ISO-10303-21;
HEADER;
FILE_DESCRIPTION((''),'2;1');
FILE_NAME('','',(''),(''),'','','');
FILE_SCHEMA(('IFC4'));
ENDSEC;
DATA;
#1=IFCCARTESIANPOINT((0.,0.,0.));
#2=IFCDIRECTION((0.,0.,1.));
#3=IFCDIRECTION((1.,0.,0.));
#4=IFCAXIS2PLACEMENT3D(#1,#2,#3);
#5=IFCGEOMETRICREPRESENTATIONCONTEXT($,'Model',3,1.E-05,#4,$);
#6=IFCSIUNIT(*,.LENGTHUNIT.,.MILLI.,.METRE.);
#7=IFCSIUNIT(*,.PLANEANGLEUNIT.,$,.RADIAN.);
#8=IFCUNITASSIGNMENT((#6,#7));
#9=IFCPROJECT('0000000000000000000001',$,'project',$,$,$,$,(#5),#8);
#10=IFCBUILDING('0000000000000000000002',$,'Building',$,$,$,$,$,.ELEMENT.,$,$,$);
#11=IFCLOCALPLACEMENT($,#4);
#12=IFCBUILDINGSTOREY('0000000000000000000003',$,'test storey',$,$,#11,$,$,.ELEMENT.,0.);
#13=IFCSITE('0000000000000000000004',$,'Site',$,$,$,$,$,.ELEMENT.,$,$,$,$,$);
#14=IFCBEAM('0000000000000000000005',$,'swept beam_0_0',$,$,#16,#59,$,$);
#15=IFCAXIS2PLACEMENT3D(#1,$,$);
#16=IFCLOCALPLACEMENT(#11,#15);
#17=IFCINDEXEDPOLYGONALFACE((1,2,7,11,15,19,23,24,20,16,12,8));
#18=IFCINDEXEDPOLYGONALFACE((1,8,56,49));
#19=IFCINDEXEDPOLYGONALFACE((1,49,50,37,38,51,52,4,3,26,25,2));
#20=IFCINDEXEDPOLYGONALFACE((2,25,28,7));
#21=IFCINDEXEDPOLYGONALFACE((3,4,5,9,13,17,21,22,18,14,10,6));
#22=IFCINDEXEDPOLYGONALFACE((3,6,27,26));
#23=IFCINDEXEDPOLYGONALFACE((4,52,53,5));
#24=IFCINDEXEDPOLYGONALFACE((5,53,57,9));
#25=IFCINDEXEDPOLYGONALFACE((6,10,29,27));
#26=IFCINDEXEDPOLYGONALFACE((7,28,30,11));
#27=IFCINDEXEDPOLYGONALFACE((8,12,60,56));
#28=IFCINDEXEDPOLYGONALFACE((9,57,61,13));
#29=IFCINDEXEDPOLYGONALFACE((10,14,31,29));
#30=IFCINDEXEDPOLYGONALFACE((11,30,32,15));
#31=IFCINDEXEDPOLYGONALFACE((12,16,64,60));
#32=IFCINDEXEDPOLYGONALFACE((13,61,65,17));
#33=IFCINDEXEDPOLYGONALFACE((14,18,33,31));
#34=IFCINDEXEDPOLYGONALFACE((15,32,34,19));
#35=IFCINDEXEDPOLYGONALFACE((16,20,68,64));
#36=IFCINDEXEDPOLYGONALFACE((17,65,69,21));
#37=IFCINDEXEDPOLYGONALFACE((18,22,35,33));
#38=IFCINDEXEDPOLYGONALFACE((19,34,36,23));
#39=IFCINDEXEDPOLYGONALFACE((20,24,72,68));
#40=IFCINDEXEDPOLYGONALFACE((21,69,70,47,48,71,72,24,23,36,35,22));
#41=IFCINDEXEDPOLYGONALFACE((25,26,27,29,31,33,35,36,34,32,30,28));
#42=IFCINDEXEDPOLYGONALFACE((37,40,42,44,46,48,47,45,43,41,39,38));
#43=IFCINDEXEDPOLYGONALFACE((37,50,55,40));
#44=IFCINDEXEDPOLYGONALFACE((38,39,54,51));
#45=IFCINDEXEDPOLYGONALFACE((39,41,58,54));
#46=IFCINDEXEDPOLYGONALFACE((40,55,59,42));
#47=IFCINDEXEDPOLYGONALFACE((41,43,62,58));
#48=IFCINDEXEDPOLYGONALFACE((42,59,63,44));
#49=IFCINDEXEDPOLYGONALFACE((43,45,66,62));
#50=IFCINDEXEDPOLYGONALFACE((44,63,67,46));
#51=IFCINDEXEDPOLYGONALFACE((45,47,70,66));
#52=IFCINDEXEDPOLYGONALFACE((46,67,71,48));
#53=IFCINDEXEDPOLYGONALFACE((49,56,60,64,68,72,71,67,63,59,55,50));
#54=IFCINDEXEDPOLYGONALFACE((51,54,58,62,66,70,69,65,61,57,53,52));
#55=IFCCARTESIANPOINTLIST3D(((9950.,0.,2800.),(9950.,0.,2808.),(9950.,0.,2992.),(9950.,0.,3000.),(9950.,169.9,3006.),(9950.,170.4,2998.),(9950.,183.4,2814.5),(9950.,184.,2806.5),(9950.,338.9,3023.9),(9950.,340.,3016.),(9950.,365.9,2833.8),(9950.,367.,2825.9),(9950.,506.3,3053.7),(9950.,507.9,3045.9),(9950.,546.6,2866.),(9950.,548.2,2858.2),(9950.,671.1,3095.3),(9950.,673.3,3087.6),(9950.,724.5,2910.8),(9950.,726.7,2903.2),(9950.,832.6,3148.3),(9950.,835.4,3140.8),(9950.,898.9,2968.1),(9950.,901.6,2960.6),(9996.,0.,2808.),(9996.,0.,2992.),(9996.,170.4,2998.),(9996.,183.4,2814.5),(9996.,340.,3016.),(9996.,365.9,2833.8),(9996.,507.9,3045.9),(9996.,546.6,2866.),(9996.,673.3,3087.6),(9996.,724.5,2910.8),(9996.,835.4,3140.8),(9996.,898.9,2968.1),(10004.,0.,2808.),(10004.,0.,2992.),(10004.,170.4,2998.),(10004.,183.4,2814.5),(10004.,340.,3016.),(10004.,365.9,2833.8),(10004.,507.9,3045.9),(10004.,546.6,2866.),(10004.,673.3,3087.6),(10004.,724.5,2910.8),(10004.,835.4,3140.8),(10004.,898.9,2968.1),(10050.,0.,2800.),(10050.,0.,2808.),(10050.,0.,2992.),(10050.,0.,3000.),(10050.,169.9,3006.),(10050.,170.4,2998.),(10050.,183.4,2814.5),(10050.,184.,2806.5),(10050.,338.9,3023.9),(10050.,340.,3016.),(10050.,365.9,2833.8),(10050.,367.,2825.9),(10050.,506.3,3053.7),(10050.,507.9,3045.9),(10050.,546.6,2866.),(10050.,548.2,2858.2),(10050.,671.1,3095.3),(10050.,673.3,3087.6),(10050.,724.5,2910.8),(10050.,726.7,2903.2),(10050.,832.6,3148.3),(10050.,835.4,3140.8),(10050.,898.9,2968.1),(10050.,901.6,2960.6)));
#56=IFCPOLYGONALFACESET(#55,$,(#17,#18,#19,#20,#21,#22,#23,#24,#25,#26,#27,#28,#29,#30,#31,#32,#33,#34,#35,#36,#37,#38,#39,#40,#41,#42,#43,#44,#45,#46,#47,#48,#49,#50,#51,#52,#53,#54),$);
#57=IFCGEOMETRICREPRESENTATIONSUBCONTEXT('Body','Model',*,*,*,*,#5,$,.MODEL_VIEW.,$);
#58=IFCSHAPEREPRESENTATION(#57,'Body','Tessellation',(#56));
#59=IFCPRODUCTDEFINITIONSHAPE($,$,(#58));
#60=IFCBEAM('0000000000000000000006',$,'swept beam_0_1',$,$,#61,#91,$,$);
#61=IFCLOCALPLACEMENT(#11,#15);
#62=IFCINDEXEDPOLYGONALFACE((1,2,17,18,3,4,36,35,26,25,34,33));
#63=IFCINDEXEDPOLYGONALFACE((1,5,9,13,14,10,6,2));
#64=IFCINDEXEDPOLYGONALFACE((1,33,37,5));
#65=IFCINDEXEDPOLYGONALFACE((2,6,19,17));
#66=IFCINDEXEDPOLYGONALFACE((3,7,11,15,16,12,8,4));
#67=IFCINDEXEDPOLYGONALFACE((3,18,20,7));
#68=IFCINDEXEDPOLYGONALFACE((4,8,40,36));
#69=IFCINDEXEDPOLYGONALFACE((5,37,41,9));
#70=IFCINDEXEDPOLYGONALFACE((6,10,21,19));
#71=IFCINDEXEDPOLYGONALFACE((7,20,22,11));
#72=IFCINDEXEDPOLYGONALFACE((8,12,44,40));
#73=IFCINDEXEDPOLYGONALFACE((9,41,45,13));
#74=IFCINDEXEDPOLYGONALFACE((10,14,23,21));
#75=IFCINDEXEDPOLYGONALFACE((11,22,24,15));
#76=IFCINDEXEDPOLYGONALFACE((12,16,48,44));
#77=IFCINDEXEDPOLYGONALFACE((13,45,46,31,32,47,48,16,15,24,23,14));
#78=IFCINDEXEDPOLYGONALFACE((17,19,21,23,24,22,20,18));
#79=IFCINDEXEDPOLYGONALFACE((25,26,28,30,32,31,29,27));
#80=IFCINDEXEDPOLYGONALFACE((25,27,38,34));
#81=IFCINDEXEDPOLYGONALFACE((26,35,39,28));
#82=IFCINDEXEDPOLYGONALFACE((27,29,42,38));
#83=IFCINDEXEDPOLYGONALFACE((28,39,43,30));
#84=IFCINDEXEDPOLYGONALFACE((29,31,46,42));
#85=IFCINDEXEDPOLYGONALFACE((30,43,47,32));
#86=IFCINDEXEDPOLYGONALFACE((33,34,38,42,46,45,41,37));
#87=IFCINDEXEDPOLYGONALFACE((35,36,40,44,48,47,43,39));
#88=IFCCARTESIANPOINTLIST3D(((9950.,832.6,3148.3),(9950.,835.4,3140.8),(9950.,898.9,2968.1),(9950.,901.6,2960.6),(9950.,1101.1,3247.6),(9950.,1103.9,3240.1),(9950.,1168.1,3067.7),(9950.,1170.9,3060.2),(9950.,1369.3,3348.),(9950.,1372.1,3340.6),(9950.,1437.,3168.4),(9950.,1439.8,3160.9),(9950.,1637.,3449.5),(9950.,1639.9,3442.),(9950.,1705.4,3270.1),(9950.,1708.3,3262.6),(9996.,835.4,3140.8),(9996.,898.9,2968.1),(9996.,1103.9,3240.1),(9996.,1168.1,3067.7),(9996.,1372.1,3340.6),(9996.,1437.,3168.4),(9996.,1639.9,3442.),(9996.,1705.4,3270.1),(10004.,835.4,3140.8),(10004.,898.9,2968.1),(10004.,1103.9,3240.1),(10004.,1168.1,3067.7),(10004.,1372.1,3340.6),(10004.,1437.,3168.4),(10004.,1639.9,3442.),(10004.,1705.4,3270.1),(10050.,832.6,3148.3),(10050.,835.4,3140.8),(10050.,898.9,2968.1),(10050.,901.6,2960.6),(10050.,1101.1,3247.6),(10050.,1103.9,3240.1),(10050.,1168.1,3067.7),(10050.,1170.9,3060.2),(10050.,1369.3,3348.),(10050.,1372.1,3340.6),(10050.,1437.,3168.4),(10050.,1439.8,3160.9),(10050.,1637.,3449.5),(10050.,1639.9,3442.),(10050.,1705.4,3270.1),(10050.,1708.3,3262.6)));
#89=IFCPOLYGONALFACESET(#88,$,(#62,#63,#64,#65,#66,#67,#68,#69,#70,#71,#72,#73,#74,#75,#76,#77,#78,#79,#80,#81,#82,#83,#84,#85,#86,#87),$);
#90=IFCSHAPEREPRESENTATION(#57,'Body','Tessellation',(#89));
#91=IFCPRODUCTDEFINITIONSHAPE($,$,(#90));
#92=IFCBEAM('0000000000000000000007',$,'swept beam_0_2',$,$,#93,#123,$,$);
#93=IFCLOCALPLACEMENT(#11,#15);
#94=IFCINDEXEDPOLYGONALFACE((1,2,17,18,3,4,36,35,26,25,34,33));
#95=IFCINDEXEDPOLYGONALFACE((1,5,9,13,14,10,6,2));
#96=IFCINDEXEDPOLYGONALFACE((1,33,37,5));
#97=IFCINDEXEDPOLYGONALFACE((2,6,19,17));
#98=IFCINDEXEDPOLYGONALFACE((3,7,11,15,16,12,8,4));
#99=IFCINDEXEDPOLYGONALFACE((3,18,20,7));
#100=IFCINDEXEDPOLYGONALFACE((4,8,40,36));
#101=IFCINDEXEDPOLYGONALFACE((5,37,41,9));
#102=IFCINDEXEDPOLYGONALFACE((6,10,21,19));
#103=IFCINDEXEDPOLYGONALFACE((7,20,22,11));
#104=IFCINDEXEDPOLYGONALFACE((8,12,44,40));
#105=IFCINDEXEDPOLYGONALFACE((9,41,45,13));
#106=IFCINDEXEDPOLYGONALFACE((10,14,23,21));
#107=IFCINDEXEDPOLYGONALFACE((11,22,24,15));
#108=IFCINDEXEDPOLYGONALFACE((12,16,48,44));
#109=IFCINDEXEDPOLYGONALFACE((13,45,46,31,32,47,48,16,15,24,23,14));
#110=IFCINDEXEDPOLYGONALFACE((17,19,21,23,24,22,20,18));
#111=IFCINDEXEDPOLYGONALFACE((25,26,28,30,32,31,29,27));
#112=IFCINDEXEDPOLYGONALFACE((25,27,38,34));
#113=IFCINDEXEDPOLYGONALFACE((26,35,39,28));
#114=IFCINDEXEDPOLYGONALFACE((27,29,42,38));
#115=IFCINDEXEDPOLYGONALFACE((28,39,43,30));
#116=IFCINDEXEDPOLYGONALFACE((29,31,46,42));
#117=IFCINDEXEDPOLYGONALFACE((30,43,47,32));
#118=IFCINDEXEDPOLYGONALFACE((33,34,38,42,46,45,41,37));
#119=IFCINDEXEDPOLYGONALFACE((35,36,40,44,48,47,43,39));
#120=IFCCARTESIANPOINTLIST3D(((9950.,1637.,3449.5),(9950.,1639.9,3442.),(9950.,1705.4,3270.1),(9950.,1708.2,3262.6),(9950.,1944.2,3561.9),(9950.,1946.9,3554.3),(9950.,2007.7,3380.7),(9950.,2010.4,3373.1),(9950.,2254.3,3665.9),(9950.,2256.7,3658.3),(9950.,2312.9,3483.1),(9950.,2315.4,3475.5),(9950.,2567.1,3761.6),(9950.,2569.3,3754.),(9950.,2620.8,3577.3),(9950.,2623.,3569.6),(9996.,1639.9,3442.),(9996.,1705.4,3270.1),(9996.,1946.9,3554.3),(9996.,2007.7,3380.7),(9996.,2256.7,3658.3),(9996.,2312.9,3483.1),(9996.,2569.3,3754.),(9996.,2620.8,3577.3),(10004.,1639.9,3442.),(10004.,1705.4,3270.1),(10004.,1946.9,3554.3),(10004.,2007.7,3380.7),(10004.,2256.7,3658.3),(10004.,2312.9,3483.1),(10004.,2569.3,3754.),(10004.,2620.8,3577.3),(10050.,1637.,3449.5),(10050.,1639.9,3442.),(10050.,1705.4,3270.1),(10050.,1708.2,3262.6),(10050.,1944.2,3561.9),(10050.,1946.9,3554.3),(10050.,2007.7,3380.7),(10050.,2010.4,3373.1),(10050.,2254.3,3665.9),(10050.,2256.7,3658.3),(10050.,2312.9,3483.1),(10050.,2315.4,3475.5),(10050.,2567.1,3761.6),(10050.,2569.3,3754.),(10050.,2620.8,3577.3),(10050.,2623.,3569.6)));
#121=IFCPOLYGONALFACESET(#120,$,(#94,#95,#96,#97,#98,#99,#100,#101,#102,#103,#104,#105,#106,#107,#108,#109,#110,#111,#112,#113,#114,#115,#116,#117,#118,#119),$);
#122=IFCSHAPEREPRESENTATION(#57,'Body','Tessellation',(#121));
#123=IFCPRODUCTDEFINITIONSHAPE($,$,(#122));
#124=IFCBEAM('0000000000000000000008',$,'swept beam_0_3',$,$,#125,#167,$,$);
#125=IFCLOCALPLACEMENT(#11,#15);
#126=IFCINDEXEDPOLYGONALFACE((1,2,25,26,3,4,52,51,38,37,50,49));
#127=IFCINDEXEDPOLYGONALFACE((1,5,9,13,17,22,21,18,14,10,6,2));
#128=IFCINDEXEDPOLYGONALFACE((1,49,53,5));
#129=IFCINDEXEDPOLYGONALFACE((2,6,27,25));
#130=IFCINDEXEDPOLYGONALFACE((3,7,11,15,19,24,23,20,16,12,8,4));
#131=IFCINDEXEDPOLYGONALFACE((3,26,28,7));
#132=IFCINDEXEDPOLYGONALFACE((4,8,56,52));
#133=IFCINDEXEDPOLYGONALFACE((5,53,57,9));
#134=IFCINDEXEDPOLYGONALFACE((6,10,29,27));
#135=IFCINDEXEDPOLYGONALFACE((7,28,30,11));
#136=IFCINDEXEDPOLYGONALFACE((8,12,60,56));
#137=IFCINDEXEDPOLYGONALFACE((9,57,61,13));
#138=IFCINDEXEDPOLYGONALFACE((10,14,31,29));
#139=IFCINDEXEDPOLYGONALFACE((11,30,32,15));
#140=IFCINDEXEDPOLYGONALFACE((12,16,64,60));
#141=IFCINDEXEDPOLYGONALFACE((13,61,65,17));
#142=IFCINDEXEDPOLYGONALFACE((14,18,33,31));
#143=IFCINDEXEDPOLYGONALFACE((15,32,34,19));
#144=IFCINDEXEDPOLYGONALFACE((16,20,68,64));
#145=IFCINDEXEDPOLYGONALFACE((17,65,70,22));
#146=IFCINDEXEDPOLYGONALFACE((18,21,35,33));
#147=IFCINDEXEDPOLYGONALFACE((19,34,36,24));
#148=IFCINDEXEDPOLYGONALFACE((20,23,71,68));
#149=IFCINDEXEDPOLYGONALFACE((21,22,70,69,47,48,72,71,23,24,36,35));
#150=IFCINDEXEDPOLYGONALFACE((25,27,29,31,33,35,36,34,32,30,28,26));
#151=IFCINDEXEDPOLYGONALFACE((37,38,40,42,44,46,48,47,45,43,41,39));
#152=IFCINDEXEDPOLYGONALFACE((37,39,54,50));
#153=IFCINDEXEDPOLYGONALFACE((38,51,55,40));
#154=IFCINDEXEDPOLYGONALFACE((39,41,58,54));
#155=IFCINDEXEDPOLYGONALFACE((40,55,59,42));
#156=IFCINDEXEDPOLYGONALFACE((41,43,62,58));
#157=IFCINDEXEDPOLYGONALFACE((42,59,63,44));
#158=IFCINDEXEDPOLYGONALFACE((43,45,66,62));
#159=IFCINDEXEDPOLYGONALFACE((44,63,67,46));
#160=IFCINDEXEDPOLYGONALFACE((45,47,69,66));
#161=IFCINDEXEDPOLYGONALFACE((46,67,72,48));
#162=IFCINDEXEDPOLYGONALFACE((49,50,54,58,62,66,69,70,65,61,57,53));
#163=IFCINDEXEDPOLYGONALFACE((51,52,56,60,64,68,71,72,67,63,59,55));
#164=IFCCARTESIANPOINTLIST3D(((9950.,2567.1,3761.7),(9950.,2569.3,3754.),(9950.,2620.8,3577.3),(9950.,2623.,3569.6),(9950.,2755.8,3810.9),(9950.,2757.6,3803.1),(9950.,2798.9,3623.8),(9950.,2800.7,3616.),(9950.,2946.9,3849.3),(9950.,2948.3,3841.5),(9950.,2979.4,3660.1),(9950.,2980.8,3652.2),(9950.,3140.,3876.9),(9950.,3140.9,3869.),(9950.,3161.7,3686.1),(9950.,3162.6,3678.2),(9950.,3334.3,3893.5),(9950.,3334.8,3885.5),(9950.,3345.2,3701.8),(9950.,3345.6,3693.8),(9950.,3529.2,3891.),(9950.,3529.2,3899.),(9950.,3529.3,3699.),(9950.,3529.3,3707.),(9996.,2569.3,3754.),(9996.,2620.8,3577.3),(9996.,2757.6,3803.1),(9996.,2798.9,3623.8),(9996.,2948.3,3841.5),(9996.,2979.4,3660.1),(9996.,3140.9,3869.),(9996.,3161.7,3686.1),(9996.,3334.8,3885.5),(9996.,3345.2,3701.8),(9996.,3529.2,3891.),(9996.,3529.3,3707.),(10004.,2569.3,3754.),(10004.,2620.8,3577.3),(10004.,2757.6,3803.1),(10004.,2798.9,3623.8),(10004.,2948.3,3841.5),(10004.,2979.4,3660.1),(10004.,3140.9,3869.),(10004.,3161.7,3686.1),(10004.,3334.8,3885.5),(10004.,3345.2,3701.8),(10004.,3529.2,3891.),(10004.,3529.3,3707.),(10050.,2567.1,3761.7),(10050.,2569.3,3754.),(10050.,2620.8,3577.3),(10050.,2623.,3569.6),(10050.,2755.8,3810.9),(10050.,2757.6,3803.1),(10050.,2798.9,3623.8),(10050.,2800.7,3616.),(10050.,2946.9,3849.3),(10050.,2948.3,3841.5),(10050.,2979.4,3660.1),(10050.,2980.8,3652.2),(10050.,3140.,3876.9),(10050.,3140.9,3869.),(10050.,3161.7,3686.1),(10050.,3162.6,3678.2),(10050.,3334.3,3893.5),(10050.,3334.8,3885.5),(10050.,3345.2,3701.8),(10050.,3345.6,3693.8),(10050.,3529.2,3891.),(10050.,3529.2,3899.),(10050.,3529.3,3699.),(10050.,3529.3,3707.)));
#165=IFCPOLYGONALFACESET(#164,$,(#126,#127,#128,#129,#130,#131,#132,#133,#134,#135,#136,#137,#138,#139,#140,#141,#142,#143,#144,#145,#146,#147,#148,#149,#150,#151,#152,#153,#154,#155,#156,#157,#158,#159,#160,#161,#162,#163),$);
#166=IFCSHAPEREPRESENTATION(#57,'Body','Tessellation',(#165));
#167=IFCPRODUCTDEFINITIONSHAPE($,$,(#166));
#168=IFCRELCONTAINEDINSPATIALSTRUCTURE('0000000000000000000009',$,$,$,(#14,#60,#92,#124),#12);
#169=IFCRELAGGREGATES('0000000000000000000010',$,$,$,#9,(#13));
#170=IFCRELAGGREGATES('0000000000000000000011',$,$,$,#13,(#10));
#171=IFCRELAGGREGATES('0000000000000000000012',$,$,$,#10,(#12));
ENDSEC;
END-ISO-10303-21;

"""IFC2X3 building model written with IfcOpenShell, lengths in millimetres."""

from ifc_helpers import new_model, entity, si_unit, origin_with_axes, place, context, subcontext, project, spatial, element, save


model = new_model("IFC2X3")

# Units and contexts
model_context = context("Model", 3, precision=1e-05, world=origin_with_axes())
body_context = subcontext(model_context, "Body", "Model", "MODEL_VIEW")
ifc_project = project(units=[si_unit("LENGTHUNIT", "METRE", prefix="MILLI"), si_unit("PLANEANGLEUNIT", "RADIAN")], contexts=[model_context])

# Site, building, storey
site = spatial("IfcSite", under=ifc_project, Name="Site", CompositionType="ELEMENT")
building = spatial("IfcBuilding", under=site, Name="Building", CompositionType="ELEMENT")
storey_placement = place(None, origin_with_axes())
storey = spatial("IfcBuildingStorey", under=building, at=storey_placement, Name="test storey", CompositionType="ELEMENT", Elevation=0.0)

# Beams
beam_1_placement = place(storey_placement, origin_with_axes())
element("IfcBeam", 1, at=beam_1_placement, inside=storey, Name="swept beam_0_0", context=body_context, shape_type="SweptSolid", body=[
    entity("IfcRevolvedAreaSolid", entity("IfcArbitraryClosedProfileDef", "AREA", None, entity("IfcPolyline", [entity("IfcCartesianPoint", [192.0, 50.0]), entity("IfcCartesianPoint", [192.0, 4.0]), entity("IfcCartesianPoint", [8.0, 4.0]), entity("IfcCartesianPoint", [8.0, 50.0]), entity("IfcCartesianPoint", [0.0, 50.0]), entity("IfcCartesianPoint", [0.0, -50.0]), entity("IfcCartesianPoint", [8.0, -50.0]), entity("IfcCartesianPoint", [8.0, -4.0]), entity("IfcCartesianPoint", [192.0, -4.0]), entity("IfcCartesianPoint", [192.0, -50.0]), entity("IfcCartesianPoint", [200.0, -50.0]), entity("IfcCartesianPoint", [200.0, 50.0]), entity("IfcCartesianPoint", [192.0, 50.0])])), entity("IfcAxis2Placement3D", entity("IfcCartesianPoint", [10000.0, 0.0, 3000.0]), entity("IfcDirection", [0.0, -1.0, 0.0]), entity("IfcDirection", [0.0, 0.0, -1.0])), entity("IfcAxis1Placement", entity("IfcCartesianPoint", [-2411.7, 0.0, 0.0]), entity("IfcDirection", [0.0, 1.0, 0.0])), 0.35249),
])
beam_2_placement = place(storey_placement, origin_with_axes())
element("IfcBeam", 2, at=beam_2_placement, inside=storey, Name="swept beam_0_1", context=body_context, shape_type="SweptSolid", body=[
    entity("IfcRevolvedAreaSolid", entity("IfcArbitraryClosedProfileDef", "AREA", None, entity("IfcPolyline", [entity("IfcCartesianPoint", [192.0, 50.0]), entity("IfcCartesianPoint", [192.0, 4.0]), entity("IfcCartesianPoint", [8.0, 4.0]), entity("IfcCartesianPoint", [8.0, 50.0]), entity("IfcCartesianPoint", [0.0, 50.0]), entity("IfcCartesianPoint", [0.0, -50.0]), entity("IfcCartesianPoint", [8.0, -50.0]), entity("IfcCartesianPoint", [8.0, -4.0]), entity("IfcCartesianPoint", [192.0, -4.0]), entity("IfcCartesianPoint", [192.0, -50.0]), entity("IfcCartesianPoint", [200.0, -50.0]), entity("IfcCartesianPoint", [200.0, 50.0]), entity("IfcCartesianPoint", [192.0, 50.0])])), entity("IfcAxis2Placement3D", entity("IfcCartesianPoint", [10000.0, 832.6, 3148.3]), entity("IfcDirection", [0.0, -0.9385, -0.3452]), entity("IfcDirection", [0.0, 0.3452, -0.9385])), entity("IfcAxis1Placement", entity("IfcCartesianPoint", [-74085.4, 0.0, 0.0]), entity("IfcDirection", [0.0, 1.0, 0.0])), 0.011595),
])
beam_3_placement = place(storey_placement, origin_with_axes())
element("IfcBeam", 3, at=beam_3_placement, inside=storey, Name="swept beam_0_2", context=body_context, shape_type="SweptSolid", body=[
    entity("IfcRevolvedAreaSolid", entity("IfcArbitraryClosedProfileDef", "AREA", None, entity("IfcPolyline", [entity("IfcCartesianPoint", [-192.0, -50.0]), entity("IfcCartesianPoint", [-192.0, -4.0]), entity("IfcCartesianPoint", [-8.0, -4.0]), entity("IfcCartesianPoint", [-8.0, -50.0]), entity("IfcCartesianPoint", [0.0, -50.0]), entity("IfcCartesianPoint", [0.0, 50.0]), entity("IfcCartesianPoint", [-8.0, 50.0]), entity("IfcCartesianPoint", [-8.0, 4.0]), entity("IfcCartesianPoint", [-192.0, 4.0]), entity("IfcCartesianPoint", [-192.0, 50.0]), entity("IfcCartesianPoint", [-200.0, 50.0]), entity("IfcCartesianPoint", [-200.0, -50.0]), entity("IfcCartesianPoint", [-192.0, -50.0])])), entity("IfcAxis2Placement3D", entity("IfcCartesianPoint", [10000.0, 1637.0, 3449.5]), entity("IfcDirection", [0.0, -0.9345, -0.3561]), entity("IfcDirection", [0.0, -0.3561, 0.9345])), entity("IfcAxis1Placement", entity("IfcCartesianPoint", [-12187.3, 0.0, 0.0]), entity("IfcDirection", [0.0, 1.0, 0.0])), 0.080516),
])
beam_4_placement = place(storey_placement, origin_with_axes())
element("IfcBeam", 4, at=beam_4_placement, inside=storey, Name="swept beam_0_3", context=body_context, shape_type="SweptSolid", body=[
    entity("IfcRevolvedAreaSolid", entity("IfcArbitraryClosedProfileDef", "AREA", None, entity("IfcPolyline", [entity("IfcCartesianPoint", [-192.0, -50.0]), entity("IfcCartesianPoint", [-192.0, -4.0]), entity("IfcCartesianPoint", [-8.0, -4.0]), entity("IfcCartesianPoint", [-8.0, -50.0]), entity("IfcCartesianPoint", [0.0, -50.0]), entity("IfcCartesianPoint", [0.0, 50.0]), entity("IfcCartesianPoint", [-8.0, 50.0]), entity("IfcCartesianPoint", [-8.0, 4.0]), entity("IfcCartesianPoint", [-192.0, 4.0]), entity("IfcCartesianPoint", [-192.0, 50.0]), entity("IfcCartesianPoint", [-200.0, 50.0]), entity("IfcCartesianPoint", [-200.0, -50.0]), entity("IfcCartesianPoint", [-192.0, -50.0])])), entity("IfcAxis2Placement3D", entity("IfcCartesianPoint", [10000.0, 2567.1, 3761.7]), entity("IfcDirection", [0.0, -0.9601, -0.2798]), entity("IfcDirection", [0.0, -0.2798, 0.9601])), entity("IfcAxis1Placement", entity("IfcCartesianPoint", [-3439.1, 0.0, 0.0]), entity("IfcDirection", [0.0, 1.0, 0.0])), 0.283569),
])

save(model, "model.ifc")
